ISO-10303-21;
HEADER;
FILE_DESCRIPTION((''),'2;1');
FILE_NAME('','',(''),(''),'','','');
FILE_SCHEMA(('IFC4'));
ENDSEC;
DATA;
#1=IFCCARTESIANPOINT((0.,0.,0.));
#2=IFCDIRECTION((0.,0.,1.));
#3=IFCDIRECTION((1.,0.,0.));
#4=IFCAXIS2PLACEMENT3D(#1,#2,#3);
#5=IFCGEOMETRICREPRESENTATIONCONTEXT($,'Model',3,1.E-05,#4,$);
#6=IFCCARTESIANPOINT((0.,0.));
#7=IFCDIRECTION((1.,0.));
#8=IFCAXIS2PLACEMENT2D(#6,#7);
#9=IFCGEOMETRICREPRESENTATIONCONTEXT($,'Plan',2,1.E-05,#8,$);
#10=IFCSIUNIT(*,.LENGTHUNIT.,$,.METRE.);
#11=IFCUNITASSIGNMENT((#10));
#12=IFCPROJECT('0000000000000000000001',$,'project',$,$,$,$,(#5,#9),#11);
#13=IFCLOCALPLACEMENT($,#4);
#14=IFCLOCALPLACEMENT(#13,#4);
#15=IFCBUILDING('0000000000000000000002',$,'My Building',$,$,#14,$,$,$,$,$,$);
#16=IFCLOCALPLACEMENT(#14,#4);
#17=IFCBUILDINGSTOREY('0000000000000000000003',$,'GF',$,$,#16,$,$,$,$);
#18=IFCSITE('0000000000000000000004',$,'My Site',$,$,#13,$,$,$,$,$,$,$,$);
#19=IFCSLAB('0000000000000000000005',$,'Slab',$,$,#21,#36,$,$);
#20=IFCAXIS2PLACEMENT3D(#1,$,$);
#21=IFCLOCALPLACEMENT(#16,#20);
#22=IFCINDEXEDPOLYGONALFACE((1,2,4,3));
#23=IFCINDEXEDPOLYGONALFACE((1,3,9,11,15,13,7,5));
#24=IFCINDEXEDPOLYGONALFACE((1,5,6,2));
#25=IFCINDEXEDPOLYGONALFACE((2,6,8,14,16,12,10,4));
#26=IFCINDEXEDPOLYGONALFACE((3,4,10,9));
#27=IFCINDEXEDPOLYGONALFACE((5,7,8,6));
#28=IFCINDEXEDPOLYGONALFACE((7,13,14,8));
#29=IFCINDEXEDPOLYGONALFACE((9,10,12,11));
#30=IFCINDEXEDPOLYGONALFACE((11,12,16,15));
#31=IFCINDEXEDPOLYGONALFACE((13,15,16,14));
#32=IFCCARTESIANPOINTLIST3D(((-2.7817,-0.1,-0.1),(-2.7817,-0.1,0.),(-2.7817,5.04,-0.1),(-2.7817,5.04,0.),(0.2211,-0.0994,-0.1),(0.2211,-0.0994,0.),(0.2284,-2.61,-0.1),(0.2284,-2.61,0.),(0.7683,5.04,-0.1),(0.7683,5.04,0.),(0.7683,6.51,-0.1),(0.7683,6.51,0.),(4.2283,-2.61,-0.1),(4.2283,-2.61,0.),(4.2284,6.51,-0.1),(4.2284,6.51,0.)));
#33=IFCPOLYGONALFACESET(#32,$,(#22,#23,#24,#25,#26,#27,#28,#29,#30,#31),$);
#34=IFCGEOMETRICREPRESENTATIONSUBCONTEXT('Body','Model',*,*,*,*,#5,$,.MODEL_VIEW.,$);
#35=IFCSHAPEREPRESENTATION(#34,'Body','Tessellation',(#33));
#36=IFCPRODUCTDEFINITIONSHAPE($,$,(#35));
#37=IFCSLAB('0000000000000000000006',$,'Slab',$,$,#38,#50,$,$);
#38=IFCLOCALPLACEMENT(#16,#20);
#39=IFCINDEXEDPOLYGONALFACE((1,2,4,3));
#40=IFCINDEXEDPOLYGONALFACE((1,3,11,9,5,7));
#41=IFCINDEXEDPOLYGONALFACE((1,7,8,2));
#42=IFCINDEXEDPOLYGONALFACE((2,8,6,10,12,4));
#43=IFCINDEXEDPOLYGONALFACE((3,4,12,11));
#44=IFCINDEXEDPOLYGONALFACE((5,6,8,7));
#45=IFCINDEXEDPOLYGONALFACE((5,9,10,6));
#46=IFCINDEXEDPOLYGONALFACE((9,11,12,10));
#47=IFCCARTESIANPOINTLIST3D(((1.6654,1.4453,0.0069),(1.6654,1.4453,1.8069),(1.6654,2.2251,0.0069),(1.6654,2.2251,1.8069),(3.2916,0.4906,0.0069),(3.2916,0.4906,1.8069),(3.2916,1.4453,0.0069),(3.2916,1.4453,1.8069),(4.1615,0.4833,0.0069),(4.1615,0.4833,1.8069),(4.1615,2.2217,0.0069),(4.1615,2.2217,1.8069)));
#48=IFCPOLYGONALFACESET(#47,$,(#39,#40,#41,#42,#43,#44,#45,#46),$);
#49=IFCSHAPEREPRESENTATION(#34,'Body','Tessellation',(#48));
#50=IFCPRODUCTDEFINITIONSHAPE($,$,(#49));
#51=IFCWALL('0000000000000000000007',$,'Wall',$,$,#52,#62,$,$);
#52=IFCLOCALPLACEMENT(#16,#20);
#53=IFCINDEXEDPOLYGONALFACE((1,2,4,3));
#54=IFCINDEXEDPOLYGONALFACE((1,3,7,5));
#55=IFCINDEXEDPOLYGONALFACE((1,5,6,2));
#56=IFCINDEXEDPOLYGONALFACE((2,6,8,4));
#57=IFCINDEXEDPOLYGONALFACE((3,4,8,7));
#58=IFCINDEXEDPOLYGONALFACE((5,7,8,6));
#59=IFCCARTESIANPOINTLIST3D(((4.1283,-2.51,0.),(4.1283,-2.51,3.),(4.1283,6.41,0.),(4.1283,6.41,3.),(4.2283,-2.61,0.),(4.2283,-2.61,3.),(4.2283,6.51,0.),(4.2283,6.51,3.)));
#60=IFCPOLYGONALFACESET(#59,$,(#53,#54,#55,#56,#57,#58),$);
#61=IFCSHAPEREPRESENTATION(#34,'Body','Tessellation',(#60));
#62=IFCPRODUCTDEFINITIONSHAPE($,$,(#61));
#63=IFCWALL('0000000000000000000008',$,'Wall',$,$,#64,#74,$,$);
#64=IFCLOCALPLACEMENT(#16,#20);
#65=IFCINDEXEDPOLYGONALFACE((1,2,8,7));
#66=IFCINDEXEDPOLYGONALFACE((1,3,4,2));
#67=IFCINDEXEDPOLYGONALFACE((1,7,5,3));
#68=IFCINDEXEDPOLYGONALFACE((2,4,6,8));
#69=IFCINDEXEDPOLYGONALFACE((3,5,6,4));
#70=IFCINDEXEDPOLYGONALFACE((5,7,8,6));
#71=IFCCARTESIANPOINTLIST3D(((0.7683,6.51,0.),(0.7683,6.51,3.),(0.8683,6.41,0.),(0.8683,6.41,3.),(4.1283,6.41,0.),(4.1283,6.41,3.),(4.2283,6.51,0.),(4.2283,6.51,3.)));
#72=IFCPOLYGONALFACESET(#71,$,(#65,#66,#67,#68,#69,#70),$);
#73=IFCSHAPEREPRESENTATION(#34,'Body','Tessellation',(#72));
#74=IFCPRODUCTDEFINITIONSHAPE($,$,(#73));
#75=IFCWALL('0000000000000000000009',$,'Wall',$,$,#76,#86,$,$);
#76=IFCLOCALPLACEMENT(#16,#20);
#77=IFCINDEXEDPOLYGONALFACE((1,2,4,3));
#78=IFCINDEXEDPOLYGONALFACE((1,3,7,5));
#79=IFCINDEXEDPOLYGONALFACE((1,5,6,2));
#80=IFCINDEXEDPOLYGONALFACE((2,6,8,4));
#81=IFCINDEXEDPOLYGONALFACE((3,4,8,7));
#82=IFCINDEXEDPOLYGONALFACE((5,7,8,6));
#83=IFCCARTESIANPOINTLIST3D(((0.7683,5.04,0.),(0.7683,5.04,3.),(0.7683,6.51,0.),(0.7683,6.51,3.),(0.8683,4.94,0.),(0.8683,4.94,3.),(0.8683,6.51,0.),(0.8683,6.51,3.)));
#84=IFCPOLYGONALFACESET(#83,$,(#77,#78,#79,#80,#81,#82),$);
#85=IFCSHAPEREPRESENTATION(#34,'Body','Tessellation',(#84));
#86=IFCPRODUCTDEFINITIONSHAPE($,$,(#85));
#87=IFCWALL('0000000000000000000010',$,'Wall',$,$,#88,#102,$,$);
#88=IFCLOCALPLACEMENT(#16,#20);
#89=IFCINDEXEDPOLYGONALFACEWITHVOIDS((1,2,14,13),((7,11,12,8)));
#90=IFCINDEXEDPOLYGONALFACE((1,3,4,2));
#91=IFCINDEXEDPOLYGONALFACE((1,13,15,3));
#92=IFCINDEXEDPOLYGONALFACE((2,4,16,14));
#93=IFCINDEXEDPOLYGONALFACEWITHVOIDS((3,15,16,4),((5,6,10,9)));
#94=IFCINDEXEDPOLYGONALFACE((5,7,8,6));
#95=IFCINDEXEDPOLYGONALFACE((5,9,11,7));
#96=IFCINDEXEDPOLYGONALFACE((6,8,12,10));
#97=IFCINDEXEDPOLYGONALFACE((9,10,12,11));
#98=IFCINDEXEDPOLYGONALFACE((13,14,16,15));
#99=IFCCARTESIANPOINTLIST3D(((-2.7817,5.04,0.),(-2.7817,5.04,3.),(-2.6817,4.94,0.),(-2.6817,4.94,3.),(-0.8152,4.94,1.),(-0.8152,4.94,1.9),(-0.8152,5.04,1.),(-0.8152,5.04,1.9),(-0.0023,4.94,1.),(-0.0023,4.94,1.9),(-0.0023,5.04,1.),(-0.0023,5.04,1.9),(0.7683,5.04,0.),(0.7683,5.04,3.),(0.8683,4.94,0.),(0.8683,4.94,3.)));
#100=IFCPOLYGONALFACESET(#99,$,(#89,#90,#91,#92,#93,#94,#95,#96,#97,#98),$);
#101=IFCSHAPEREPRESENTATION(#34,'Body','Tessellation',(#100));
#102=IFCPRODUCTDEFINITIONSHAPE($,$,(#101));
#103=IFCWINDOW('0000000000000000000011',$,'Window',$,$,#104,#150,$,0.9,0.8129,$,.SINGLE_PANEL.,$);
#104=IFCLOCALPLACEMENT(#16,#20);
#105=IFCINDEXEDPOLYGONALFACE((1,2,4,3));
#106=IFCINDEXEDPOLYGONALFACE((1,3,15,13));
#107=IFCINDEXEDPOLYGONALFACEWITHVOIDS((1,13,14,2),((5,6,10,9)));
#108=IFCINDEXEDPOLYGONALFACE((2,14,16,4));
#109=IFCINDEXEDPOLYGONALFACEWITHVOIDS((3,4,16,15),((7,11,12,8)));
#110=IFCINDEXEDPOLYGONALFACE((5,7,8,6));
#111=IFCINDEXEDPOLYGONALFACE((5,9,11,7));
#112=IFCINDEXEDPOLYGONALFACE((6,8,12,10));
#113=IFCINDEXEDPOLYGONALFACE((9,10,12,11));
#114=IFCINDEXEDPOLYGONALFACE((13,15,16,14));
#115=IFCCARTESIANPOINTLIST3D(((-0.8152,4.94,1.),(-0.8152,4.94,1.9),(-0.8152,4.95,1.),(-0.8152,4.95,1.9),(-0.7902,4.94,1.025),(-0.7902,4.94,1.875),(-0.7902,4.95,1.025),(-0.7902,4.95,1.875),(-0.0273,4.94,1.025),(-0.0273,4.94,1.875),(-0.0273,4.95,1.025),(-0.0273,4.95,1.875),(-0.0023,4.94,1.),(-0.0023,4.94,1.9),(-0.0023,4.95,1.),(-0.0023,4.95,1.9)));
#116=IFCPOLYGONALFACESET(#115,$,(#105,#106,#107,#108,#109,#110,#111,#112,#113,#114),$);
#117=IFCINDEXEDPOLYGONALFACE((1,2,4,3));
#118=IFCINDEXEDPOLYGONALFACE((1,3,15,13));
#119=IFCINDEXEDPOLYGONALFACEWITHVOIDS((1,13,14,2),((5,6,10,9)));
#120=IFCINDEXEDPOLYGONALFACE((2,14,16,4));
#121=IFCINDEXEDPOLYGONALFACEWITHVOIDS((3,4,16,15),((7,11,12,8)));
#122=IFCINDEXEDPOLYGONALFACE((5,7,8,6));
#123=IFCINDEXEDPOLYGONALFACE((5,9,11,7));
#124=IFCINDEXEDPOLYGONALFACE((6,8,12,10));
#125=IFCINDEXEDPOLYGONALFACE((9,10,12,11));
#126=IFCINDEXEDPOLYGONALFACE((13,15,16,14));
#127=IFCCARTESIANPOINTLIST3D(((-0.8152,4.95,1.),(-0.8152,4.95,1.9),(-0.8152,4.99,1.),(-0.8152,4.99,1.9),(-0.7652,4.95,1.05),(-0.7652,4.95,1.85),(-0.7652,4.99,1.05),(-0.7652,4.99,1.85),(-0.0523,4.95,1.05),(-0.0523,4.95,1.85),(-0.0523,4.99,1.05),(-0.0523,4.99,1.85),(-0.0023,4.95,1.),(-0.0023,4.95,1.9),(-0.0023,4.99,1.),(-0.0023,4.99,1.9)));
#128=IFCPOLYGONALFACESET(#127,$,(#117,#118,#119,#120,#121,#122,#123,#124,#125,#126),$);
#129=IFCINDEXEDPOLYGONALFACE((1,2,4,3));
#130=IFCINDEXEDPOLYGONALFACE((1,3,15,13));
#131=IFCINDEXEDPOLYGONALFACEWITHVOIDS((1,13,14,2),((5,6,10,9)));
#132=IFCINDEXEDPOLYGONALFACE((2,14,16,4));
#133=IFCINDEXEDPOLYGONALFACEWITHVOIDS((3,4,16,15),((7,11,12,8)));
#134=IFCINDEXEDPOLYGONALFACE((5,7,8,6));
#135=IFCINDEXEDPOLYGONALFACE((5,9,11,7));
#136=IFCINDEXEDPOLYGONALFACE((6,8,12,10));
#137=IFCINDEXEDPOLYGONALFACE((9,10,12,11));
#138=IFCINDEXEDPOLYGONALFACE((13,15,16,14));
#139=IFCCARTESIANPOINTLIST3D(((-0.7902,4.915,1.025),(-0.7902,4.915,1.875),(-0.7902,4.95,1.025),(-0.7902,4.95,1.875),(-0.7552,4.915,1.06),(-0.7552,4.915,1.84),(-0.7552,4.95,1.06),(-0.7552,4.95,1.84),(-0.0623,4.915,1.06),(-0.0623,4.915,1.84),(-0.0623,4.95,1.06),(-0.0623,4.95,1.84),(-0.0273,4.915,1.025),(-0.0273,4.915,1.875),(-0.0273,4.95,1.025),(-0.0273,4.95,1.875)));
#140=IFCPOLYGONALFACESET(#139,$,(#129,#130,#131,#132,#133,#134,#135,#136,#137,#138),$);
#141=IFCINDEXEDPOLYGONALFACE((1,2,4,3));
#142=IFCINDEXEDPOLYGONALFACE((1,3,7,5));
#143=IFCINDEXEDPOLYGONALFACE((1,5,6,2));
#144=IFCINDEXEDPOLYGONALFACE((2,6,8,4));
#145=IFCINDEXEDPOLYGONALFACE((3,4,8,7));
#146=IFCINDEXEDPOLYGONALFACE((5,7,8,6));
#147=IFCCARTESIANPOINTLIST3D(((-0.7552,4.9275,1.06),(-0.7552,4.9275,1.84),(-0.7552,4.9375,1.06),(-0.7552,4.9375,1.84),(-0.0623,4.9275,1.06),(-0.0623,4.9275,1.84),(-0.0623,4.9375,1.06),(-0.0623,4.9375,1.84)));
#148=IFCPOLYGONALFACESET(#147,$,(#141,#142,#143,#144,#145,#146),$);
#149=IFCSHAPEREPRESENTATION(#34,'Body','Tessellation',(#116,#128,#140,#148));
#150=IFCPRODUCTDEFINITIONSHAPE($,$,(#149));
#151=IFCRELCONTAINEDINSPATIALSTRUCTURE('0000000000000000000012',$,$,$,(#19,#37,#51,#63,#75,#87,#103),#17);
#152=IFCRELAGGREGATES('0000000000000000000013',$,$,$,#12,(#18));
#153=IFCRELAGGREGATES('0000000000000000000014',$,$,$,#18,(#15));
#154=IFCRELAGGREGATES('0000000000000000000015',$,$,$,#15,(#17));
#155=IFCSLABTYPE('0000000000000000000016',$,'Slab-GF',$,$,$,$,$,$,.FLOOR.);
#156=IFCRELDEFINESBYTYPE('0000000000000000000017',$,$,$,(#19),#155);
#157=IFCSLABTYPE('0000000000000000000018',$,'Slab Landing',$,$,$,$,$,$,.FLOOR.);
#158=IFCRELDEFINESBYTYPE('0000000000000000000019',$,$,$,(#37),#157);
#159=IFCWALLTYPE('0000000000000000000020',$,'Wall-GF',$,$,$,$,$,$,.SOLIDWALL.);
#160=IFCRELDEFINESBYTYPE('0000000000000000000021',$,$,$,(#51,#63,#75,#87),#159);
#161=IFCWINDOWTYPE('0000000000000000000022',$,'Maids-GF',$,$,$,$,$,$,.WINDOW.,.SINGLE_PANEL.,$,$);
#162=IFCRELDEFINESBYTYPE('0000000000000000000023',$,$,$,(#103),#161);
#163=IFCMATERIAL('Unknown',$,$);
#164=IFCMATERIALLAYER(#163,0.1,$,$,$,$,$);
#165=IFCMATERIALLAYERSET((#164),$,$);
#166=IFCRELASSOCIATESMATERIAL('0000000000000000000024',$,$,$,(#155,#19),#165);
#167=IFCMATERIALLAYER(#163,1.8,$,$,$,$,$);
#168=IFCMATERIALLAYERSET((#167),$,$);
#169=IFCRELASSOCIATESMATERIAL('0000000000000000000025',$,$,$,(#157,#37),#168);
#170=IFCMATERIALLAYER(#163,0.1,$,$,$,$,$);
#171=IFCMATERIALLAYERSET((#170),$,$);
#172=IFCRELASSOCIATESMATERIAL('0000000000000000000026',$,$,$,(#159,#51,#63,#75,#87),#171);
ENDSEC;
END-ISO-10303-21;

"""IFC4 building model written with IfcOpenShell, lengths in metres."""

from ifc_helpers import new_model, entity, si_unit, frame, origin_with_axes, origin_2d_with_axis, place, context, subcontext, project, spatial, line, indexed_curve, outline, extrude, shape, source, transform, mapped, material, layer, layer_set, layer_usage, type_object, type_shapes, element, fill, save


model = new_model("IFC4")

# Units and contexts
model_context = context("Model", 3, precision=1e-05, world=origin_with_axes())
plan_context = context("Plan", 2, precision=1e-05, world=origin_2d_with_axis())
body_context_1 = subcontext(model_context, "Body", "Model", "MODEL_VIEW")
body_context_2 = subcontext(plan_context, "Body", "Plan", "PLAN_VIEW")
ifc_project = project(units=[si_unit("LENGTHUNIT", "METRE")], contexts=[model_context, plan_context])

# Site, building, storey
site_placement = place(None, origin_with_axes())
site = spatial("IfcSite", under=ifc_project, at=site_placement, Name="My Site")
building_placement = place(site_placement, origin_with_axes())
building = spatial("IfcBuilding", under=site, at=building_placement, Name="My Building")
storey_placement = place(building_placement, origin_with_axes())
storey = spatial("IfcBuildingStorey", under=building, at=storey_placement, Name="GF")

# Slabs
ifc_material_1 = material(Name="Unknown")
ifc_layer_1 = layer(ifc_material_1, 0.1)
ifc_layer_set_1 = layer_set([ifc_layer_1])
ifc_layer_usage_1 = layer_usage(ifc_layer_set_1, "AXIS3", "POSITIVE", -0.1)
slab_type_1 = type_object("IfcSlabType", Name="Slab-GF", PredefinedType="FLOOR", material=ifc_layer_set_1)
slab_1_placement = place(storey_placement, frame((4.2283, -2.61, 0.0), z_axis=(0.0, 0.0, 1.0), x_axis=(1.0, 0.0, 0.0)))
element("IfcSlab", 1, at=slab_1_placement, inside=storey, type_object=slab_type_1, material=ifc_layer_usage_1, Name="Slab", context=body_context_1, shape_type="SweptSolid", body=[
    extrude(outline(indexed_curve([(0.0, 0.0), (0.0, 9.12), (-3.46, 9.12), (-3.46, 7.65), (-7.01, 7.65), (-7.01, 2.51), (-4.0073, 2.5106), (-4.0, 0.0), (0.0, 0.0)])), frame((0.0, 0.0, -0.1), z_axis=(0.0, 0.0, 1.0), x_axis=(1.0, 0.0, 0.0)), (0.0, 0.0, 1.0), 0.1),
])
ifc_layer_2 = layer(ifc_material_1, 1.8)
ifc_layer_set_2 = layer_set([ifc_layer_2])
ifc_layer_usage_2 = layer_usage(ifc_layer_set_2, "AXIS3", "POSITIVE", -1.8)
slab_type_2 = type_object("IfcSlabType", Name="Slab Landing", PredefinedType="FLOOR", material=ifc_layer_set_2)
slab_2_placement = place(storey_placement, frame((1.6654, 2.2251, 1.8069), z_axis=(0.0, 0.0, 1.0), x_axis=(1.0, 0.0, 0.0)))
element("IfcSlab", 2, at=slab_2_placement, inside=storey, type_object=slab_type_2, material=ifc_layer_usage_2, Name="Slab", context=body_context_1, shape_type="SweptSolid", body=[
    extrude(outline(indexed_curve([(2.4962, -0.0034), (2.4962, -1.7418), (1.6262, -1.7345), (1.6262, -0.7798), (0.0, -0.7798), (0.0, 0.0), (2.4962, -0.0034)])), frame((0.0, 0.0, -1.8), z_axis=(0.0, 0.0, 1.0), x_axis=(1.0, 0.0, 0.0)), (0.0, 0.0, 1.0), 1.8),
])

# Shared definitions
ifc_layer_3 = layer(ifc_material_1, 0.1)
ifc_layer_set_3 = layer_set([ifc_layer_3])
wall_type = type_object("IfcWallType", Name="Wall-GF", PredefinedType="SOLIDWALL", material=ifc_layer_set_3)

# Walls
ifc_layer_usage_3 = layer_usage(ifc_layer_set_3, "AXIS2", "POSITIVE", 0.0)
wall_1_placement = place(storey_placement, frame((4.2283, -2.61, 0.0), z_axis=(0.0, 0.0, 1.0), x_axis=(0.0, 1.0, 0.0)))
element("IfcWall", 3, at=wall_1_placement, inside=storey, type_object=wall_type, material=ifc_layer_usage_3, Name="Wall", context=body_context_1, shape_type="SweptSolid", body=[
    extrude(outline(indexed_curve([(0.0, 0.0), (0.1, 0.1), (9.02, 0.1), (9.12, 0.0)], segments=[line(1, 2, 3, 4, 1)])), origin_with_axes(), (0.0, 0.0, 1.0), 3.0),
])
ifc_layer_usage_4 = layer_usage(ifc_layer_set_3, "AXIS2", "POSITIVE", 0.0)
wall_2_placement = place(storey_placement, frame((4.2283, 6.51, 0.0), z_axis=(0.0, 0.0, 1.0), x_axis=(-1.0, 0.0, 0.0)))
element("IfcWall", 4, at=wall_2_placement, inside=storey, type_object=wall_type, material=ifc_layer_usage_4, Name="Wall", context=body_context_1, shape_type="SweptSolid", body=[
    extrude(outline(indexed_curve([(0.0, 0.0), (0.1, 0.1), (3.36, 0.1), (3.46, 0.0)], segments=[line(1, 2, 3, 4, 1)])), origin_with_axes(), (0.0, 0.0, 1.0), 3.0),
])
ifc_layer_usage_5 = layer_usage(ifc_layer_set_3, "AXIS2", "POSITIVE", 0.0)
wall_3_placement = place(storey_placement, frame((0.7683, 6.51, 0.0), z_axis=(0.0, 0.0, 1.0), x_axis=(0.0, -1.0, 0.0)))
element("IfcWall", 5, at=wall_3_placement, inside=storey, type_object=wall_type, material=ifc_layer_usage_5, Name="Wall", context=body_context_1, shape_type="SweptSolid", body=[
    extrude(outline(indexed_curve([(0.0, 0.0), (0.0, 0.1), (1.57, 0.1), (1.47, 0.0)], segments=[line(1, 2, 3, 4, 1)])), origin_with_axes(), (0.0, 0.0, 1.0), 3.0),
])

# Wall, opening, window
ifc_layer_usage_6 = layer_usage(ifc_layer_set_3, "AXIS2", "POSITIVE", 0.0)
wall_4_placement = place(storey_placement, frame((0.7683, 5.04, 0.0), z_axis=(0.0, 0.0, 1.0), x_axis=(-1.0, 0.0, 0.0)))
wall_4 = element("IfcWall", 6, at=wall_4_placement, inside=storey, type_object=wall_type, material=ifc_layer_usage_6, Name="Wall", context=body_context_1, shape_type="SweptSolid", body=[
    extrude(outline(indexed_curve([(0.0, 0.0), (-0.1, 0.1), (3.45, 0.1), (3.55, 0.0)], segments=[line(1, 2, 3, 4, 1)])), origin_with_axes(), (0.0, 0.0, 1.0), 3.0),
])
shared_shape_1 = source(origin_with_axes(), body_context_1, "Body", "SweptSolid", [
    extrude(outline(indexed_curve([(0.0, 0.0), (0.8129, 0.0), (0.8129, 0.9), (0.0, 0.9)], segments=[line(1, 2, 3, 4, 1)])), frame((0.0, -0.6, 0.0), z_axis=(0.0, -1.0, 0.0), x_axis=(1.0, 0.0, 0.0)), (0.0, 0.0, -1.0), 1.2),
])
opening_1_placement = place(wall_4_placement, frame((0.7707, 0.0, 1.0), z_axis=(0.0, 0.0, 1.0), x_axis=(1.0, 0.0, 0.0)))
opening_1 = element("IfcOpeningElement", 7, at=opening_1_placement, cuts=wall_4, PredefinedType="OPENING", context=body_context_1, shape_type="MappedRepresentation", body=[
    mapped(shared_shape_1, transform((0.0, 0.0, 0.0), x_axis=(1.0, 0.0, 0.0), y_axis=(0.0, 1.0, 0.0), z_axis=(0.0, 0.0, 1.0), scale=1.0)),
])
window_type_1 = type_object("IfcWindowType", Name="Maids-GF", PartitioningType="SINGLE_PANEL", PredefinedType="WINDOW")
shared_shape_2 = source(origin_with_axes(), body_context_1, "Body", "SweptSolid", [
    extrude(outline(indexed_curve([(0.0, 0.0), (0.8129, 0.0), (0.8129, 0.9), (0.0, 0.9)], segments=[line(1, 2, 3, 4, 1)]), holes=[indexed_curve([(0.025, 0.025), (0.7879, 0.025), (0.7879, 0.875), (0.025, 0.875)], segments=[line(1, 2, 3, 4, 1)])]), frame((0.0, 0.09, 0.0), z_axis=(0.0, -1.0, 0.0), x_axis=(1.0, 0.0, 0.0)), (0.0, 0.0, -1.0), 0.01),
    extrude(outline(indexed_curve([(0.0, 0.0), (0.8129, 0.0), (0.8129, 0.9), (0.0, 0.9)], segments=[line(1, 2, 3, 4, 1)]), holes=[indexed_curve([(0.05, 0.05), (0.7629, 0.05), (0.7629, 0.85), (0.05, 0.85)], segments=[line(1, 2, 3, 4, 1)])]), frame((0.0, 0.05, 0.0), z_axis=(0.0, -1.0, 0.0), x_axis=(1.0, 0.0, 0.0)), (0.0, 0.0, -1.0), 0.04),
    extrude(outline(indexed_curve([(0.0, 0.0), (0.7629, 0.0), (0.7629, 0.85), (0.0, 0.85)], segments=[line(1, 2, 3, 4, 1)]), holes=[indexed_curve([(0.035, 0.035), (0.7279, 0.035), (0.7279, 0.815), (0.035, 0.815)], segments=[line(1, 2, 3, 4, 1)])]), frame((0.025, 0.09, 0.025), z_axis=(0.0, -1.0, 0.0), x_axis=(1.0, 0.0, 0.0)), (0.0, 0.0, -1.0), 0.035),
    extrude(outline(indexed_curve([(0.035, 0.035), (0.7279, 0.035), (0.7279, 0.815), (0.035, 0.815)], segments=[line(1, 2, 3, 4, 1)])), frame((0.025, 0.1025, 0.025), z_axis=(0.0, -1.0, 0.0), x_axis=(1.0, 0.0, 0.0)), (0.0, 0.0, -1.0), 0.01),
])
shared_shape_3 = source(origin_with_axes(), body_context_2, "Body", "Curve2D", [
    entity("IfcIndexedPolyCurve", entity("IfcCartesianPointList2D", [[0.05, 0.05], [0.7629, 0.05]])),
    entity("IfcIndexedPolyCurve", entity("IfcCartesianPointList2D", [[0.0, 0.1], [0.025, 0.1], [0.025, 0.09], [0.05, 0.09], [0.05, 0.05], [0.0, 0.05]]), [entity("IfcLineIndex", [1, 2, 3, 4, 5, 6, 1])]),
    entity("IfcIndexedPolyCurve", entity("IfcCartesianPointList2D", [[0.8129, 0.1], [0.7879, 0.1], [0.7879, 0.09], [0.7629, 0.09], [0.7629, 0.05], [0.8129, 0.05]]), [entity("IfcLineIndex", [1, 2, 3, 4, 5, 6, 1])]),
    entity("IfcIndexedPolyCurve", entity("IfcCartesianPointList2D", [[0.025, 0.09], [0.06, 0.09], [0.06, 0.125], [0.025, 0.125]]), [entity("IfcLineIndex", [1, 2, 3, 4, 1])]),
    entity("IfcIndexedPolyCurve", entity("IfcCartesianPointList2D", [[0.7879, 0.09], [0.7529, 0.09], [0.7529, 0.125], [0.7879, 0.125]]), [entity("IfcLineIndex", [1, 2, 3, 4, 1])]),
    entity("IfcIndexedPolyCurve", entity("IfcCartesianPointList2D", [[0.06, 0.09], [0.7529, 0.09]])),
    entity("IfcIndexedPolyCurve", entity("IfcCartesianPointList2D", [[0.06, 0.125], [0.7529, 0.125]])),
    entity("IfcIndexedPolyCurve", entity("IfcCartesianPointList2D", [[0.06, 0.1075], [0.7529, 0.1075]])),
])
type_shapes(window_type_1, [shared_shape_2, shared_shape_3])
window_1_placement = place(opening_1_placement, frame((0.0, 0.0, 0.0), z_axis=(0.0, 0.0, 1.0), x_axis=(1.0, 0.0, 0.0)))
window_1 = element("IfcWindow", 8, at=window_1_placement, inside=storey, type_object=window_type_1, Name="Window", OverallHeight=0.9, OverallWidth=0.8129, PartitioningType="SINGLE_PANEL", shapes=[
    shape(body_context_1, "Body", "MappedRepresentation", [mapped(shared_shape_2, transform((0.0, 0.0, 0.0), x_axis=(1.0, 0.0, 0.0), y_axis=(0.0, 1.0, 0.0), z_axis=(0.0, 0.0, 1.0), scale=1.0))]),
    shape(body_context_2, "Body", "MappedRepresentation", [mapped(shared_shape_3, transform((0.0, 0.0, 0.0), x_axis=(1.0, 0.0, 0.0), y_axis=(0.0, 1.0, 0.0), z_axis=(0.0, 0.0, 1.0), scale=1.0))]),
])
fill(opening_1, window_1)

save(model, "model.ifc")
